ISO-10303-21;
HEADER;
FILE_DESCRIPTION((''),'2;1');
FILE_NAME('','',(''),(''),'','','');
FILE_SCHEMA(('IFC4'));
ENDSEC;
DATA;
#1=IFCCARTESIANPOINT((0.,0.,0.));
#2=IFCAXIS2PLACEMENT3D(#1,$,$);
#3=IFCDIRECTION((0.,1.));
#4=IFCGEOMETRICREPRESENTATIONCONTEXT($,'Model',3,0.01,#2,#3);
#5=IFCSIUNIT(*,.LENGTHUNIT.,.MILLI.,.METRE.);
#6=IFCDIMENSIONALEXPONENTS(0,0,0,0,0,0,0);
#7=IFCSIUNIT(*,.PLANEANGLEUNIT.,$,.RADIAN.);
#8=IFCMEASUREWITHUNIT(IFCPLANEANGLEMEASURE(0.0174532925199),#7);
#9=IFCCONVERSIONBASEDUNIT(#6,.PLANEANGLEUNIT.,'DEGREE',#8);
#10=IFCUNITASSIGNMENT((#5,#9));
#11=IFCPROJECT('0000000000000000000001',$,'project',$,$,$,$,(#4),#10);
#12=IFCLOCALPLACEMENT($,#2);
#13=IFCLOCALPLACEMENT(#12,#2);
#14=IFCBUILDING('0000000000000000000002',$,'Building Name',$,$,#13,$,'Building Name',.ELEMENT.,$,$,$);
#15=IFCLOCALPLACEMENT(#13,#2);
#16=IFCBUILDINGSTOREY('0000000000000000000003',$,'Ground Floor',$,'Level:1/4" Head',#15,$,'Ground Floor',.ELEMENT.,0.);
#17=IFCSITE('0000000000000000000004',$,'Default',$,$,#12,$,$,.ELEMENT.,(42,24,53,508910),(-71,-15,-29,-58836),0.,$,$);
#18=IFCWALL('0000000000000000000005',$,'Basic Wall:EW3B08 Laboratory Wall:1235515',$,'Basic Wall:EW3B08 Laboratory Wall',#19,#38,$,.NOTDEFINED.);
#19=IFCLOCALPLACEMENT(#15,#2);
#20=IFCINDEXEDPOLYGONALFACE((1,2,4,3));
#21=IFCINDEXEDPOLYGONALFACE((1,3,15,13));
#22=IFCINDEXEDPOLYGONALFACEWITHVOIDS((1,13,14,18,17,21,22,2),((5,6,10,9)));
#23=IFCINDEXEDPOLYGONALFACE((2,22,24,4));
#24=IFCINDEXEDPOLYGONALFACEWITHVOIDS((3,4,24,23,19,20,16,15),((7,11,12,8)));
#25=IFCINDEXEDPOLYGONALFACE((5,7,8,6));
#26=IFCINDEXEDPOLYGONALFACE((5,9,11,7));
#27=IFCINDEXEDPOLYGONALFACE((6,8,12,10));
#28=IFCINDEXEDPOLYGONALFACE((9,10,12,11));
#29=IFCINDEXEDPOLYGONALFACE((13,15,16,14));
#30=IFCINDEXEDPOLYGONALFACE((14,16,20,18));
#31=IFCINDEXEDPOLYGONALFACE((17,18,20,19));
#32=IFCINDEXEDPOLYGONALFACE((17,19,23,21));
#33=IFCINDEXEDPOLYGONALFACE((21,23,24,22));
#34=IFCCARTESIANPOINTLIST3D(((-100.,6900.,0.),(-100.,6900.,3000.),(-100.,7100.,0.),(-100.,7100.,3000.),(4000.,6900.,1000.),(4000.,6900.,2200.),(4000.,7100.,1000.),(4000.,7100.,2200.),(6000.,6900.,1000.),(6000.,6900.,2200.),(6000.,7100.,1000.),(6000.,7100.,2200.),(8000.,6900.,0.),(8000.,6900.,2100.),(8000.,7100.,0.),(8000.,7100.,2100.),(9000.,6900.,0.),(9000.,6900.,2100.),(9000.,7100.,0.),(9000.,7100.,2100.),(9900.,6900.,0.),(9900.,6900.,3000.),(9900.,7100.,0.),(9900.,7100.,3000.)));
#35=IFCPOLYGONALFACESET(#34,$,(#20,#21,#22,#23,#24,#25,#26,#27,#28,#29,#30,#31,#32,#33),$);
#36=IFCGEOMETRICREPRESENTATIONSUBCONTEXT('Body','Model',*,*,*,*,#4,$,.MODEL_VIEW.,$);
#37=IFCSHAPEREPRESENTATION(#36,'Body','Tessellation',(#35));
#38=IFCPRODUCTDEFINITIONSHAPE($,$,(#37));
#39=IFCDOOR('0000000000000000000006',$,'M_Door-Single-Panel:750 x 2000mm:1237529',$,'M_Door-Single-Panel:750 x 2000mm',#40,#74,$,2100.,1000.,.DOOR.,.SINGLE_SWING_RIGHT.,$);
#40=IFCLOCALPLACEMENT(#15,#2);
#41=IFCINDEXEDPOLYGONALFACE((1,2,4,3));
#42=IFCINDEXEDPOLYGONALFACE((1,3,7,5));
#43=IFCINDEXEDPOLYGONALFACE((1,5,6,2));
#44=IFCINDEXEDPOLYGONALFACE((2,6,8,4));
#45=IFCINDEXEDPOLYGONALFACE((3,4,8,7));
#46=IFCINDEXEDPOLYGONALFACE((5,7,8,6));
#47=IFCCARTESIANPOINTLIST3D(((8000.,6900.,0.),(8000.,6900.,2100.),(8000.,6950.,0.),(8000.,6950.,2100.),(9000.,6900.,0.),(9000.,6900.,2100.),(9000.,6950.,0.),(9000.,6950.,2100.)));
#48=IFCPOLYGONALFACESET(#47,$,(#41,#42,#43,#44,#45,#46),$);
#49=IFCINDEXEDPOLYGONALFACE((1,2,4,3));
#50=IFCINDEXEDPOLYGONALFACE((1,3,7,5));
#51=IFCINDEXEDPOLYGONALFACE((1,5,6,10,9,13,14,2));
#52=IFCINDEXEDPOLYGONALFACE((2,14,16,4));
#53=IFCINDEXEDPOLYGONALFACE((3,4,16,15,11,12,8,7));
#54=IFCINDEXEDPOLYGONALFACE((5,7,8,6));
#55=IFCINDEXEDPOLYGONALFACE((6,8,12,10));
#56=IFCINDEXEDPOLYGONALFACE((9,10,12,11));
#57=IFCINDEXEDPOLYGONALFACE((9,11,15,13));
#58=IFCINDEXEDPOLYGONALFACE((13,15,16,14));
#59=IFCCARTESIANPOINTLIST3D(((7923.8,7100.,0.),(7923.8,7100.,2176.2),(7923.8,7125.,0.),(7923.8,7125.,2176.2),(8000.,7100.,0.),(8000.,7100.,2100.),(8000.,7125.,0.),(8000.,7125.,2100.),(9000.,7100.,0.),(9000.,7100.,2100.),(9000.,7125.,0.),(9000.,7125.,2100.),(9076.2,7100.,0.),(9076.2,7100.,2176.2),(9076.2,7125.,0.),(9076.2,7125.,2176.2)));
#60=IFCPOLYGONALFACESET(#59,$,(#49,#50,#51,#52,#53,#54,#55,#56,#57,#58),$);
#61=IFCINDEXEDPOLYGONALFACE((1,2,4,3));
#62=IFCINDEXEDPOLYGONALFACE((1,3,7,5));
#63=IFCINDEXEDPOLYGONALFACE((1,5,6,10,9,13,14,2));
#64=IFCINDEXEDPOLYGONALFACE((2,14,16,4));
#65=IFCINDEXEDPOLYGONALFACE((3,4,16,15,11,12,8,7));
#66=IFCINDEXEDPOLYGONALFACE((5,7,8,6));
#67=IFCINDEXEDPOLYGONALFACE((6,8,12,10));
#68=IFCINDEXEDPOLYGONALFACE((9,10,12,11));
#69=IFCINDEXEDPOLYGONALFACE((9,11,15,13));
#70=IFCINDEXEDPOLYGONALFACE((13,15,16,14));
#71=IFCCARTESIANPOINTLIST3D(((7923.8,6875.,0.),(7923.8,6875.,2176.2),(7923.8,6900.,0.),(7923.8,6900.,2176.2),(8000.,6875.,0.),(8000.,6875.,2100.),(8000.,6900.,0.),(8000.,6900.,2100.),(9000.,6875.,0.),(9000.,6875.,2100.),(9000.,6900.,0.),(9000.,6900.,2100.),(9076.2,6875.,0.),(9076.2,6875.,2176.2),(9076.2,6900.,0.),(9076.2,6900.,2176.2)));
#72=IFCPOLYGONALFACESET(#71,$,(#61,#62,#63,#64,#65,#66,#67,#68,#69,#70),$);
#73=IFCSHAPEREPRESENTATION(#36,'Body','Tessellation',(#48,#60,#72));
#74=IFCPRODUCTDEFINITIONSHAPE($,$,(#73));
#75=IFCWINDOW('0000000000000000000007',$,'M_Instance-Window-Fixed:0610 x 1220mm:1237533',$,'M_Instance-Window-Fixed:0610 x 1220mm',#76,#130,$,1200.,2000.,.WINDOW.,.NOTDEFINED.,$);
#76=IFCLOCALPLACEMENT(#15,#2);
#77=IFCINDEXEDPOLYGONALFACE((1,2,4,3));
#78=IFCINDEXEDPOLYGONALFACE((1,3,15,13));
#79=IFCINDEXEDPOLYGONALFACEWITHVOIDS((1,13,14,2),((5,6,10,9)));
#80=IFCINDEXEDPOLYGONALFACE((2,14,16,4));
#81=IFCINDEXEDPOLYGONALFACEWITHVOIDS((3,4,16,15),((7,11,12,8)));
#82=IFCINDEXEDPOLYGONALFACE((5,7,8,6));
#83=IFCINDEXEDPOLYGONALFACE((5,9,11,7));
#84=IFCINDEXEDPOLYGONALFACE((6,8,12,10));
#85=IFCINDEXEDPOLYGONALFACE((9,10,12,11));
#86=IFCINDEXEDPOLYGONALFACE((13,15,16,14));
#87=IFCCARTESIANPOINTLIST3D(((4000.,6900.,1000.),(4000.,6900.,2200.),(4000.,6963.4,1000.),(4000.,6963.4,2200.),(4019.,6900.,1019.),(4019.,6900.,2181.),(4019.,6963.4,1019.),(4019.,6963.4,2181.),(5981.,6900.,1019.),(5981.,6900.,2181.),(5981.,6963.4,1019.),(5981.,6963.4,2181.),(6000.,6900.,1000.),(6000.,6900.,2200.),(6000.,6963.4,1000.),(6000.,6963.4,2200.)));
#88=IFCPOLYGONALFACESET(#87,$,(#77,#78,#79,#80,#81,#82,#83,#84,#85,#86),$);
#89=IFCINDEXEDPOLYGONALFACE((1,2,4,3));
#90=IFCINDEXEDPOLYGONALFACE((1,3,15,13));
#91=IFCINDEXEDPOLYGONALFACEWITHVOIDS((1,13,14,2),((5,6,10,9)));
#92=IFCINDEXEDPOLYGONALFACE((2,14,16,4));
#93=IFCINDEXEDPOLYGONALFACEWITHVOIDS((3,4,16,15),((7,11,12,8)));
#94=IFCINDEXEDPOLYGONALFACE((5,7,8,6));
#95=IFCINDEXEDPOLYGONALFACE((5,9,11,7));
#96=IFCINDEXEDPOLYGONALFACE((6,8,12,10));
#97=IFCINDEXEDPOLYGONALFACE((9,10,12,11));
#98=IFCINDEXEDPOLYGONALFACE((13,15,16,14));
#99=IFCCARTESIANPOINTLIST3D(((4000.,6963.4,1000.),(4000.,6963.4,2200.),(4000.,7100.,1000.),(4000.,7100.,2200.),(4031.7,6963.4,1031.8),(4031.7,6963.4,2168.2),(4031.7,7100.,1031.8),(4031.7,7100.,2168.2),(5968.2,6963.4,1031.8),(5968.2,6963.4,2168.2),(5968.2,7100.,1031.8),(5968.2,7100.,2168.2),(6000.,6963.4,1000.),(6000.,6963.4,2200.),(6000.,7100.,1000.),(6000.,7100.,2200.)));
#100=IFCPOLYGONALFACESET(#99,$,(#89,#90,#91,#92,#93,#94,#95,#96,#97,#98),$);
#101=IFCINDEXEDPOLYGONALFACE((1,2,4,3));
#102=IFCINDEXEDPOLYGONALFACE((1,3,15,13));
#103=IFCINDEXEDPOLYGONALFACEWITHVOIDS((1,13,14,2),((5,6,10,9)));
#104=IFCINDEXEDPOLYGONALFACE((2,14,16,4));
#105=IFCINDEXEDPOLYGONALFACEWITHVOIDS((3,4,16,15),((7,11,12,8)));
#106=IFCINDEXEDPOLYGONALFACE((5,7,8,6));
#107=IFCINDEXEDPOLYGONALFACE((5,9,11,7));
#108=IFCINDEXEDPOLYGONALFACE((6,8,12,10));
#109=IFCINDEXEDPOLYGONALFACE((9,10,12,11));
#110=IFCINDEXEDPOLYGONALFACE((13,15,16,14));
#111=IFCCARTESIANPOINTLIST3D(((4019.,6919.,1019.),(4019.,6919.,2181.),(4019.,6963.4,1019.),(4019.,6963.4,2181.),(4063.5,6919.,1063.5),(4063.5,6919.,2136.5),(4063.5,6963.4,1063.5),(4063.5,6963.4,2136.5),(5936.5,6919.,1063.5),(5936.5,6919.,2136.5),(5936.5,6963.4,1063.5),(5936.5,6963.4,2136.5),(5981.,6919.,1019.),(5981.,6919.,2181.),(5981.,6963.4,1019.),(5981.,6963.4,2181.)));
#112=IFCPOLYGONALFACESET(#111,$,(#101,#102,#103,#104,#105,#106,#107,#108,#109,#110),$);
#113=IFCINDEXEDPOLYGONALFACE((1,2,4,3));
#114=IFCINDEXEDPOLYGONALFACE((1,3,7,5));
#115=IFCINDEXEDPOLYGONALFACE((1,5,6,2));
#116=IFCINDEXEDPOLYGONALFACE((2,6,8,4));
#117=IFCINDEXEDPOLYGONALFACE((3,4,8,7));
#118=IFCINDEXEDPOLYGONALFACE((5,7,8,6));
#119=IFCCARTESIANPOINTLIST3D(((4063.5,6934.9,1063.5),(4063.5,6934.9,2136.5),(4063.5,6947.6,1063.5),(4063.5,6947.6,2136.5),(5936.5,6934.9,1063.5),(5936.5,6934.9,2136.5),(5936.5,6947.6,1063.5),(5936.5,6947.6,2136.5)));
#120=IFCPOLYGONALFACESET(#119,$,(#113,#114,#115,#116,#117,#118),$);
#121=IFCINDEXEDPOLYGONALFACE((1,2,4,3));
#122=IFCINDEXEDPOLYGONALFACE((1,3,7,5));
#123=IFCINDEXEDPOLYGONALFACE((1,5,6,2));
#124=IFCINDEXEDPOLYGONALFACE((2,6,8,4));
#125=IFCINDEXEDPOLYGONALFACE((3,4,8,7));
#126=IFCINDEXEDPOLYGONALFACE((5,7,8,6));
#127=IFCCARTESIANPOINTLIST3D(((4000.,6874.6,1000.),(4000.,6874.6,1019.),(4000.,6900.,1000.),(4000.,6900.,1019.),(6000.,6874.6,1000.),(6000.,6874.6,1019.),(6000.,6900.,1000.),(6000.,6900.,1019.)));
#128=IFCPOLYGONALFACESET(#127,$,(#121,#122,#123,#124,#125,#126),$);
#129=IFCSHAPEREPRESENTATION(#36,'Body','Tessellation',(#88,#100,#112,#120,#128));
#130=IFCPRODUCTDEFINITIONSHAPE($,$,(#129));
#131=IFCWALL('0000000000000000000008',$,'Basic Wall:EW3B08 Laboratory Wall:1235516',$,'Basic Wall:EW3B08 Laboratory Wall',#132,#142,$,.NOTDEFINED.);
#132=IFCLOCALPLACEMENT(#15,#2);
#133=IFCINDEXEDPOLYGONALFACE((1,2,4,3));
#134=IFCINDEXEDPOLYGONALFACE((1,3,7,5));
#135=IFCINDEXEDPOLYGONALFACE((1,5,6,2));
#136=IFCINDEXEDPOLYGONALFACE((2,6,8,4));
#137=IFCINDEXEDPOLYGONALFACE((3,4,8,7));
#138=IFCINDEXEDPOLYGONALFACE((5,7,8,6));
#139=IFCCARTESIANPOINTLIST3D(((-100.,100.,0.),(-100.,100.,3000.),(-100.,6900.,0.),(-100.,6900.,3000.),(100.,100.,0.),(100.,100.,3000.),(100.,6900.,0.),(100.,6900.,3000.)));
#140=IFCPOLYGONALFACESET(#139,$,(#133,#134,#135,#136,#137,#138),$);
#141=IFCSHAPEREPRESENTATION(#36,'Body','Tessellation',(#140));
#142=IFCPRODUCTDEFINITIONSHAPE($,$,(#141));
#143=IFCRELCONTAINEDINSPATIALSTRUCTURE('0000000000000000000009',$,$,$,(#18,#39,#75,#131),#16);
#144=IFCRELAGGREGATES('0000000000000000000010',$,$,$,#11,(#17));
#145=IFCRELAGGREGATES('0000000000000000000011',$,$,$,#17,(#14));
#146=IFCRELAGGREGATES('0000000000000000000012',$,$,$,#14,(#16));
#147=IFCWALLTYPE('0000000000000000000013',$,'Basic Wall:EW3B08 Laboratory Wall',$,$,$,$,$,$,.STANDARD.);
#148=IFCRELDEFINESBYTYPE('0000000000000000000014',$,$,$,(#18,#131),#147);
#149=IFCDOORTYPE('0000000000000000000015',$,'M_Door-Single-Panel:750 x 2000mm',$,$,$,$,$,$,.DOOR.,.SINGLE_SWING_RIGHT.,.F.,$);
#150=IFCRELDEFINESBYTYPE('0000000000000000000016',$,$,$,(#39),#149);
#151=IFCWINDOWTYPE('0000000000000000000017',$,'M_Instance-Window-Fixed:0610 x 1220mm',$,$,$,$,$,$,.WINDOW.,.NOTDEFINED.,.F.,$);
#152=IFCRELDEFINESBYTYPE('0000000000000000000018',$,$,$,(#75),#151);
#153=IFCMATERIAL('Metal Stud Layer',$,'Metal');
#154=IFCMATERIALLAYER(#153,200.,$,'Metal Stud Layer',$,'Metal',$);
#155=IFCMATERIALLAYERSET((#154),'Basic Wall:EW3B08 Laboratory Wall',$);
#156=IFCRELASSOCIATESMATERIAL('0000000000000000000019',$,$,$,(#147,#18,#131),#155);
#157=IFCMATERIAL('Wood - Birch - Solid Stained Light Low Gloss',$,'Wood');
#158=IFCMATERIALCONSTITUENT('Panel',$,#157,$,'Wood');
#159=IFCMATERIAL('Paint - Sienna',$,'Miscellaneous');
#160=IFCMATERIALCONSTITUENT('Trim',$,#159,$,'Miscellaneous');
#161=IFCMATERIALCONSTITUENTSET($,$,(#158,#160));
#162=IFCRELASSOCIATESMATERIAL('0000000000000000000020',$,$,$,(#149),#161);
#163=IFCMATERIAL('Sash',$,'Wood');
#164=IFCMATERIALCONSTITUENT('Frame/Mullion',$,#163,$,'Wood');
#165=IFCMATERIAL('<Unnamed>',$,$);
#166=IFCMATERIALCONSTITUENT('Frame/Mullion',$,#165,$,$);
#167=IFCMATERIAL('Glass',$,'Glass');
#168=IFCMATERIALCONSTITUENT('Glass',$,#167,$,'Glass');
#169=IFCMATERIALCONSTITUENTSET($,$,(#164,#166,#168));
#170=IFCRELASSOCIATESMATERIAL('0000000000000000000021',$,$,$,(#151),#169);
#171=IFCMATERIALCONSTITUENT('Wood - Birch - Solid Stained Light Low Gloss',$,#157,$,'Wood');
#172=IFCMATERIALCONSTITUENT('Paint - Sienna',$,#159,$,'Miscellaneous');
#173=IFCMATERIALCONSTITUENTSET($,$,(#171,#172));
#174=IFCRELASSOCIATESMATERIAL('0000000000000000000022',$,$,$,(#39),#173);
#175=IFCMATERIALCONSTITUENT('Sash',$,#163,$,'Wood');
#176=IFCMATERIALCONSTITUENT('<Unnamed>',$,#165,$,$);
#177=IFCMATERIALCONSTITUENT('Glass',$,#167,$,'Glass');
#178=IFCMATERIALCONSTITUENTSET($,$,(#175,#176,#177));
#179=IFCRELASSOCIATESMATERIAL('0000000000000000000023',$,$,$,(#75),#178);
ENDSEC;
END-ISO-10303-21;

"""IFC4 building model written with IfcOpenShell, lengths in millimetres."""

from ifc_helpers import new_model, entity, si_unit, converted_unit, direction, frame, frame_2d, origin, place, context, subcontext, project, spatial, polyline, rectangle, outline, extrude, source, transform, mapped, material, layer, layer_set, layer_usage, constituent, constituent_set, type_object, type_shapes, element, fill, save


model = new_model("IFC4")

# Units and contexts
model_context = context("Model", 3, precision=0.01, world=origin(), true_north=direction((0.0, 1.0)))
body_context = subcontext(model_context, "Body", "Model", "MODEL_VIEW")
ifc_project = project(units=[si_unit("LENGTHUNIT", "METRE", prefix="MILLI"), converted_unit("PLANEANGLEUNIT", "DEGREE", entity("IfcPlaneAngleMeasure", 0.0174532925199), si_unit("PLANEANGLEUNIT", "RADIAN"), dimensions=[0, 0, 0, 0, 0, 0, 0])], contexts=[model_context])

# Site, building, storey
site_placement = place(None, origin())
site = spatial("IfcSite", under=ifc_project, at=site_placement, Name="Default", CompositionType="ELEMENT", RefLatitude=(42, 24, 53, 508910), RefLongitude=(-71, -15, -29, -58836), RefElevation=0.0)
building_placement = place(site_placement, origin())
building = spatial("IfcBuilding", under=site, at=building_placement, Name="Building Name", LongName="Building Name", CompositionType="ELEMENT")
storey_placement = place(building_placement, origin())
storey = spatial("IfcBuildingStorey", under=building, at=storey_placement, Name="Ground Floor", ObjectType="Level:1/4\" Head", LongName="Ground Floor", CompositionType="ELEMENT", Elevation=0.0)

# Shared definitions
ifc_material_1 = material(Name="Metal Stud Layer", Category="Metal")
ifc_layer_1 = layer(ifc_material_1, 200.0, Name="Metal Stud Layer", Category="Metal")
ifc_layer_set_1 = layer_set([ifc_layer_1], Name="Basic Wall:EW3B08 Laboratory Wall")
wall_type = type_object("IfcWallType", Name="Basic Wall:EW3B08 Laboratory Wall", PredefinedType="STANDARD", material=ifc_layer_set_1)
ifc_material_2 = material(Name="Wood - Birch - Solid Stained Light Low Gloss", Category="Wood")
ifc_material_3 = material(Name="Paint - Sienna", Category="Miscellaneous")
ifc_constituent_1 = constituent(ifc_material_2, Name="Panel", Category="Wood")
ifc_constituent_2 = constituent(ifc_material_3, Name="Trim", Category="Miscellaneous")
ifc_constituent_set_1 = constituent_set(constituents=[ifc_constituent_1, ifc_constituent_2])
door_type = type_object("IfcDoorType", Name="M_Door-Single-Panel:750 x 2000mm", OperationType="SINGLE_SWING_RIGHT", ParameterTakesPrecedence=False, PredefinedType="DOOR", material=ifc_constituent_set_1)
shared_shape_1 = source(origin(), body_context, "Body", "SweptSolid", [
    extrude(rectangle(XDim=50.0, YDim=1000.0, at=frame_2d((0.0, 0.0), x_axis=(1.0, 0.0))), frame((500.0, 175.0, 0.0), z_axis=(0.0, 0.0, 1.0), x_axis=(0.0, 1.0, 0.0)), (0.0, 0.0, 1.0), 2100.0),
    extrude(outline(polyline([(-1107.2, -576.2), (1069.0, -576.2), (1069.0, -500.0), (-1031.0, -500.0), (-1031.0, 500.0), (1069.0, 500.0), (1069.0, 576.2), (-1107.2, 576.2), (-1107.2, -576.2)])), frame((500.0, -25.0, 1069.0), z_axis=(0.0, 1.0, 0.0), x_axis=(0.0, 0.0, -1.0)), (0.0, 0.0, 1.0), 25.0),
    extrude(outline(polyline([(-576.2, -1107.2), (576.2, -1107.2), (576.2, 1069.0), (500.0, 1069.0), (500.0, -1031.0), (-500.0, -1031.0), (-500.0, 1069.0), (-576.2, 1069.0), (-576.2, -1107.2)])), frame((500.0, 200.0, 1069.0), z_axis=(0.0, 1.0, 0.0), x_axis=(1.0, 0.0, 0.0)), (0.0, 0.0, 1.0), 25.0),
])
type_shapes(door_type, [shared_shape_1])
ifc_material_4 = material(Name="Sash", Category="Wood")
ifc_material_5 = material(Name="<Unnamed>")
ifc_material_6 = material(Name="Glass", Category="Glass")
ifc_constituent_3 = constituent(ifc_material_4, Name="Frame/Mullion", Category="Wood")
ifc_constituent_4 = constituent(ifc_material_5, Name="Frame/Mullion")
ifc_constituent_5 = constituent(ifc_material_6, Name="Glass", Category="Glass")
ifc_constituent_set_2 = constituent_set(constituents=[ifc_constituent_3, ifc_constituent_4, ifc_constituent_5])
window_type = type_object("IfcWindowType", Name="M_Instance-Window-Fixed:0610 x 1220mm", ParameterTakesPrecedence=False, PartitioningType="NOTDEFINED", PredefinedType="WINDOW", material=ifc_constituent_set_2)
shared_shape_2 = source(origin(), body_context, "Body", "SweptSolid", [
    extrude(outline(polyline([(-600.0, -1000.0), (600.0, -1000.0), (600.0, 1000.0), (-600.0, 1000.0), (-600.0, -1000.0)]), holes=[polyline([(-581.0, -981.0), (-581.0, 981.0), (581.0, 981.0), (581.0, -981.0), (-581.0, -981.0)])]), frame((1000.0, 136.6, 600.0), z_axis=(0.0, 1.0, 0.0), x_axis=(0.0, 0.0, -1.0)), (0.0, 0.0, 1.0), 63.5),
    extrude(outline(polyline([(-1000.0, -600.0), (1000.0, -600.0), (1000.0, 600.0), (-1000.0, 600.0), (-1000.0, -600.0)]), holes=[polyline([(-968.2, -568.2), (-968.2, 568.2), (968.2, 568.2), (968.2, -568.2), (-968.2, -568.2)])]), frame((1000.0, 0.0, 600.0), z_axis=(0.0, 1.0, 0.0), x_axis=(1.0, 0.0, 0.0)), (0.0, 0.0, 1.0), 136.6),
    extrude(outline(polyline([(-981.0, -581.0), (981.0, -581.0), (981.0, 581.0), (-981.0, 581.0), (-981.0, -581.0)]), holes=[polyline([(-936.5, -536.5), (-936.5, 536.5), (936.5, 536.5), (936.5, -536.5), (-936.5, -536.5)])]), frame((1000.0, 136.6, 600.0), z_axis=(0.0, 1.0, 0.0), x_axis=(1.0, 0.0, 0.0)), (0.0, 0.0, 1.0), 44.5),
    extrude(rectangle(XDim=12.7, YDim=1873.0, at=frame_2d((0.0, 0.0), x_axis=(1.0, 0.0))), frame((1000.0, 158.8, 63.5), z_axis=(0.0, 0.0, 1.0), x_axis=(0.0, 1.0, 0.0)), (0.0, 0.0, 1.0), 1073.0),
    extrude(rectangle(XDim=25.4, YDim=2000.0, at=frame_2d((0.0, 0.0), x_axis=(1.0, 0.0))), frame((1000.0, 212.7, 0.0), z_axis=(0.0, 0.0, 1.0), x_axis=(0.0, -1.0, 0.0)), (0.0, 0.0, 1.0), 19.1),
])
type_shapes(window_type, [shared_shape_2])

# Wall, openings, door, window
ifc_layer_usage_1 = layer_usage(ifc_layer_set_1, "AXIS2", "NEGATIVE", 100.0)
wall_1_placement = place(storey_placement, frame((9900.0, 7000.0, 0.0), z_axis=(0.0, 0.0, 1.0), x_axis=(-1.0, 0.0, 0.0)))
wall_1 = element("IfcWall", 1, at=wall_1_placement, inside=storey, type_object=wall_type, material=ifc_layer_usage_1, Name="Basic Wall:EW3B08 Laboratory Wall:1235515", ObjectType="Basic Wall:EW3B08 Laboratory Wall", PredefinedType="NOTDEFINED", context=body_context, shape_type="SweptSolid", body=[
    extrude(rectangle(XDim=10000.0, YDim=200.0, at=frame_2d((5000.0, 0.0), x_axis=(1.0, 0.0))), origin(), (0.0, 0.0, 1.0), 3000.0),
])
opening_1_placement = place(wall_1_placement, frame((900.0, -100.0, 0.0)))
opening_1 = element("IfcOpeningElement", 2, at=opening_1_placement, cuts=wall_1, PredefinedType="OPENING", context=body_context, shape_type="SweptSolid", body=[
    extrude(rectangle(XDim=1000.0, YDim=2100.0, at=frame_2d((1050.0, 500.0), x_axis=(0.0, 1.0))), frame((0.0, 0.0, 0.0), z_axis=(0.0, 1.0, 0.0), x_axis=(0.0, 0.0, 1.0)), (0.0, 0.0, 1.0), 200.0),
])
opening_2_placement = place(wall_1_placement, frame((3900.0, -100.0, 1000.0)))
opening_2 = element("IfcOpeningElement", 3, at=opening_2_placement, cuts=wall_1, PredefinedType="OPENING", context=body_context, shape_type="SweptSolid", body=[
    extrude(rectangle(XDim=1200.0, YDim=2000.0, at=frame_2d((600.0, 1000.0), x_axis=(-1.0, 0.0))), frame((0.0, 0.0, 0.0), z_axis=(0.0, 1.0, 0.0), x_axis=(0.0, 0.0, 1.0)), (0.0, 0.0, 1.0), 200.0),
])
ifc_constituent_6 = constituent(ifc_material_2, Name="Wood - Birch - Solid Stained Light Low Gloss", Category="Wood")
ifc_constituent_7 = constituent(ifc_material_3, Name="Paint - Sienna", Category="Miscellaneous")
ifc_constituent_set_3 = constituent_set(constituents=[ifc_constituent_6, ifc_constituent_7])
door_1_placement = place(opening_1_placement, origin())
door_1 = element("IfcDoor", 4, at=door_1_placement, inside=storey, type_object=door_type, material=ifc_constituent_set_3, Name="M_Door-Single-Panel:750 x 2000mm:1237529", ObjectType="M_Door-Single-Panel:750 x 2000mm", OperationType="SINGLE_SWING_RIGHT", OverallHeight=2100.0, OverallWidth=1000.0, PredefinedType="DOOR", context=body_context, shape_type="MappedRepresentation", body=[
    mapped(shared_shape_1, transform((0.0, 0.0, 0.0), scale=1.0)),
])
fill(opening_1, door_1)
ifc_constituent_8 = constituent(ifc_material_4, Name="Sash", Category="Wood")
ifc_constituent_9 = constituent(ifc_material_5, Name="<Unnamed>")
ifc_constituent_10 = constituent(ifc_material_6, Name="Glass", Category="Glass")
ifc_constituent_set_4 = constituent_set(constituents=[ifc_constituent_8, ifc_constituent_9, ifc_constituent_10])
window_1_placement = place(opening_2_placement, origin())
window_1 = element("IfcWindow", 5, at=window_1_placement, inside=storey, type_object=window_type, material=ifc_constituent_set_4, Name="M_Instance-Window-Fixed:0610 x 1220mm:1237533", ObjectType="M_Instance-Window-Fixed:0610 x 1220mm", OverallHeight=1200.0, OverallWidth=2000.0, PartitioningType="NOTDEFINED", PredefinedType="WINDOW", context=body_context, shape_type="MappedRepresentation", body=[
    mapped(shared_shape_2, transform((0.0, 0.0, 0.0), scale=1.0)),
])
fill(opening_2, window_1)

# Wall
ifc_layer_usage_2 = layer_usage(ifc_layer_set_1, "AXIS2", "NEGATIVE", 100.0)
wall_2_placement = place(storey_placement, frame((0.0, 6900.0, 0.0), z_axis=(0.0, 0.0, 1.0), x_axis=(0.0, -1.0, 0.0)))
element("IfcWall", 6, at=wall_2_placement, inside=storey, type_object=wall_type, material=ifc_layer_usage_2, Name="Basic Wall:EW3B08 Laboratory Wall:1235516", ObjectType="Basic Wall:EW3B08 Laboratory Wall", PredefinedType="NOTDEFINED", context=body_context, shape_type="SweptSolid", body=[
    extrude(rectangle(XDim=6800.0, YDim=200.0, at=frame_2d((3400.0, 0.0), x_axis=(-1.0, 0.0))), origin(), (0.0, 0.0, 1.0), 3000.0),
])

save(model, "model.ifc")
